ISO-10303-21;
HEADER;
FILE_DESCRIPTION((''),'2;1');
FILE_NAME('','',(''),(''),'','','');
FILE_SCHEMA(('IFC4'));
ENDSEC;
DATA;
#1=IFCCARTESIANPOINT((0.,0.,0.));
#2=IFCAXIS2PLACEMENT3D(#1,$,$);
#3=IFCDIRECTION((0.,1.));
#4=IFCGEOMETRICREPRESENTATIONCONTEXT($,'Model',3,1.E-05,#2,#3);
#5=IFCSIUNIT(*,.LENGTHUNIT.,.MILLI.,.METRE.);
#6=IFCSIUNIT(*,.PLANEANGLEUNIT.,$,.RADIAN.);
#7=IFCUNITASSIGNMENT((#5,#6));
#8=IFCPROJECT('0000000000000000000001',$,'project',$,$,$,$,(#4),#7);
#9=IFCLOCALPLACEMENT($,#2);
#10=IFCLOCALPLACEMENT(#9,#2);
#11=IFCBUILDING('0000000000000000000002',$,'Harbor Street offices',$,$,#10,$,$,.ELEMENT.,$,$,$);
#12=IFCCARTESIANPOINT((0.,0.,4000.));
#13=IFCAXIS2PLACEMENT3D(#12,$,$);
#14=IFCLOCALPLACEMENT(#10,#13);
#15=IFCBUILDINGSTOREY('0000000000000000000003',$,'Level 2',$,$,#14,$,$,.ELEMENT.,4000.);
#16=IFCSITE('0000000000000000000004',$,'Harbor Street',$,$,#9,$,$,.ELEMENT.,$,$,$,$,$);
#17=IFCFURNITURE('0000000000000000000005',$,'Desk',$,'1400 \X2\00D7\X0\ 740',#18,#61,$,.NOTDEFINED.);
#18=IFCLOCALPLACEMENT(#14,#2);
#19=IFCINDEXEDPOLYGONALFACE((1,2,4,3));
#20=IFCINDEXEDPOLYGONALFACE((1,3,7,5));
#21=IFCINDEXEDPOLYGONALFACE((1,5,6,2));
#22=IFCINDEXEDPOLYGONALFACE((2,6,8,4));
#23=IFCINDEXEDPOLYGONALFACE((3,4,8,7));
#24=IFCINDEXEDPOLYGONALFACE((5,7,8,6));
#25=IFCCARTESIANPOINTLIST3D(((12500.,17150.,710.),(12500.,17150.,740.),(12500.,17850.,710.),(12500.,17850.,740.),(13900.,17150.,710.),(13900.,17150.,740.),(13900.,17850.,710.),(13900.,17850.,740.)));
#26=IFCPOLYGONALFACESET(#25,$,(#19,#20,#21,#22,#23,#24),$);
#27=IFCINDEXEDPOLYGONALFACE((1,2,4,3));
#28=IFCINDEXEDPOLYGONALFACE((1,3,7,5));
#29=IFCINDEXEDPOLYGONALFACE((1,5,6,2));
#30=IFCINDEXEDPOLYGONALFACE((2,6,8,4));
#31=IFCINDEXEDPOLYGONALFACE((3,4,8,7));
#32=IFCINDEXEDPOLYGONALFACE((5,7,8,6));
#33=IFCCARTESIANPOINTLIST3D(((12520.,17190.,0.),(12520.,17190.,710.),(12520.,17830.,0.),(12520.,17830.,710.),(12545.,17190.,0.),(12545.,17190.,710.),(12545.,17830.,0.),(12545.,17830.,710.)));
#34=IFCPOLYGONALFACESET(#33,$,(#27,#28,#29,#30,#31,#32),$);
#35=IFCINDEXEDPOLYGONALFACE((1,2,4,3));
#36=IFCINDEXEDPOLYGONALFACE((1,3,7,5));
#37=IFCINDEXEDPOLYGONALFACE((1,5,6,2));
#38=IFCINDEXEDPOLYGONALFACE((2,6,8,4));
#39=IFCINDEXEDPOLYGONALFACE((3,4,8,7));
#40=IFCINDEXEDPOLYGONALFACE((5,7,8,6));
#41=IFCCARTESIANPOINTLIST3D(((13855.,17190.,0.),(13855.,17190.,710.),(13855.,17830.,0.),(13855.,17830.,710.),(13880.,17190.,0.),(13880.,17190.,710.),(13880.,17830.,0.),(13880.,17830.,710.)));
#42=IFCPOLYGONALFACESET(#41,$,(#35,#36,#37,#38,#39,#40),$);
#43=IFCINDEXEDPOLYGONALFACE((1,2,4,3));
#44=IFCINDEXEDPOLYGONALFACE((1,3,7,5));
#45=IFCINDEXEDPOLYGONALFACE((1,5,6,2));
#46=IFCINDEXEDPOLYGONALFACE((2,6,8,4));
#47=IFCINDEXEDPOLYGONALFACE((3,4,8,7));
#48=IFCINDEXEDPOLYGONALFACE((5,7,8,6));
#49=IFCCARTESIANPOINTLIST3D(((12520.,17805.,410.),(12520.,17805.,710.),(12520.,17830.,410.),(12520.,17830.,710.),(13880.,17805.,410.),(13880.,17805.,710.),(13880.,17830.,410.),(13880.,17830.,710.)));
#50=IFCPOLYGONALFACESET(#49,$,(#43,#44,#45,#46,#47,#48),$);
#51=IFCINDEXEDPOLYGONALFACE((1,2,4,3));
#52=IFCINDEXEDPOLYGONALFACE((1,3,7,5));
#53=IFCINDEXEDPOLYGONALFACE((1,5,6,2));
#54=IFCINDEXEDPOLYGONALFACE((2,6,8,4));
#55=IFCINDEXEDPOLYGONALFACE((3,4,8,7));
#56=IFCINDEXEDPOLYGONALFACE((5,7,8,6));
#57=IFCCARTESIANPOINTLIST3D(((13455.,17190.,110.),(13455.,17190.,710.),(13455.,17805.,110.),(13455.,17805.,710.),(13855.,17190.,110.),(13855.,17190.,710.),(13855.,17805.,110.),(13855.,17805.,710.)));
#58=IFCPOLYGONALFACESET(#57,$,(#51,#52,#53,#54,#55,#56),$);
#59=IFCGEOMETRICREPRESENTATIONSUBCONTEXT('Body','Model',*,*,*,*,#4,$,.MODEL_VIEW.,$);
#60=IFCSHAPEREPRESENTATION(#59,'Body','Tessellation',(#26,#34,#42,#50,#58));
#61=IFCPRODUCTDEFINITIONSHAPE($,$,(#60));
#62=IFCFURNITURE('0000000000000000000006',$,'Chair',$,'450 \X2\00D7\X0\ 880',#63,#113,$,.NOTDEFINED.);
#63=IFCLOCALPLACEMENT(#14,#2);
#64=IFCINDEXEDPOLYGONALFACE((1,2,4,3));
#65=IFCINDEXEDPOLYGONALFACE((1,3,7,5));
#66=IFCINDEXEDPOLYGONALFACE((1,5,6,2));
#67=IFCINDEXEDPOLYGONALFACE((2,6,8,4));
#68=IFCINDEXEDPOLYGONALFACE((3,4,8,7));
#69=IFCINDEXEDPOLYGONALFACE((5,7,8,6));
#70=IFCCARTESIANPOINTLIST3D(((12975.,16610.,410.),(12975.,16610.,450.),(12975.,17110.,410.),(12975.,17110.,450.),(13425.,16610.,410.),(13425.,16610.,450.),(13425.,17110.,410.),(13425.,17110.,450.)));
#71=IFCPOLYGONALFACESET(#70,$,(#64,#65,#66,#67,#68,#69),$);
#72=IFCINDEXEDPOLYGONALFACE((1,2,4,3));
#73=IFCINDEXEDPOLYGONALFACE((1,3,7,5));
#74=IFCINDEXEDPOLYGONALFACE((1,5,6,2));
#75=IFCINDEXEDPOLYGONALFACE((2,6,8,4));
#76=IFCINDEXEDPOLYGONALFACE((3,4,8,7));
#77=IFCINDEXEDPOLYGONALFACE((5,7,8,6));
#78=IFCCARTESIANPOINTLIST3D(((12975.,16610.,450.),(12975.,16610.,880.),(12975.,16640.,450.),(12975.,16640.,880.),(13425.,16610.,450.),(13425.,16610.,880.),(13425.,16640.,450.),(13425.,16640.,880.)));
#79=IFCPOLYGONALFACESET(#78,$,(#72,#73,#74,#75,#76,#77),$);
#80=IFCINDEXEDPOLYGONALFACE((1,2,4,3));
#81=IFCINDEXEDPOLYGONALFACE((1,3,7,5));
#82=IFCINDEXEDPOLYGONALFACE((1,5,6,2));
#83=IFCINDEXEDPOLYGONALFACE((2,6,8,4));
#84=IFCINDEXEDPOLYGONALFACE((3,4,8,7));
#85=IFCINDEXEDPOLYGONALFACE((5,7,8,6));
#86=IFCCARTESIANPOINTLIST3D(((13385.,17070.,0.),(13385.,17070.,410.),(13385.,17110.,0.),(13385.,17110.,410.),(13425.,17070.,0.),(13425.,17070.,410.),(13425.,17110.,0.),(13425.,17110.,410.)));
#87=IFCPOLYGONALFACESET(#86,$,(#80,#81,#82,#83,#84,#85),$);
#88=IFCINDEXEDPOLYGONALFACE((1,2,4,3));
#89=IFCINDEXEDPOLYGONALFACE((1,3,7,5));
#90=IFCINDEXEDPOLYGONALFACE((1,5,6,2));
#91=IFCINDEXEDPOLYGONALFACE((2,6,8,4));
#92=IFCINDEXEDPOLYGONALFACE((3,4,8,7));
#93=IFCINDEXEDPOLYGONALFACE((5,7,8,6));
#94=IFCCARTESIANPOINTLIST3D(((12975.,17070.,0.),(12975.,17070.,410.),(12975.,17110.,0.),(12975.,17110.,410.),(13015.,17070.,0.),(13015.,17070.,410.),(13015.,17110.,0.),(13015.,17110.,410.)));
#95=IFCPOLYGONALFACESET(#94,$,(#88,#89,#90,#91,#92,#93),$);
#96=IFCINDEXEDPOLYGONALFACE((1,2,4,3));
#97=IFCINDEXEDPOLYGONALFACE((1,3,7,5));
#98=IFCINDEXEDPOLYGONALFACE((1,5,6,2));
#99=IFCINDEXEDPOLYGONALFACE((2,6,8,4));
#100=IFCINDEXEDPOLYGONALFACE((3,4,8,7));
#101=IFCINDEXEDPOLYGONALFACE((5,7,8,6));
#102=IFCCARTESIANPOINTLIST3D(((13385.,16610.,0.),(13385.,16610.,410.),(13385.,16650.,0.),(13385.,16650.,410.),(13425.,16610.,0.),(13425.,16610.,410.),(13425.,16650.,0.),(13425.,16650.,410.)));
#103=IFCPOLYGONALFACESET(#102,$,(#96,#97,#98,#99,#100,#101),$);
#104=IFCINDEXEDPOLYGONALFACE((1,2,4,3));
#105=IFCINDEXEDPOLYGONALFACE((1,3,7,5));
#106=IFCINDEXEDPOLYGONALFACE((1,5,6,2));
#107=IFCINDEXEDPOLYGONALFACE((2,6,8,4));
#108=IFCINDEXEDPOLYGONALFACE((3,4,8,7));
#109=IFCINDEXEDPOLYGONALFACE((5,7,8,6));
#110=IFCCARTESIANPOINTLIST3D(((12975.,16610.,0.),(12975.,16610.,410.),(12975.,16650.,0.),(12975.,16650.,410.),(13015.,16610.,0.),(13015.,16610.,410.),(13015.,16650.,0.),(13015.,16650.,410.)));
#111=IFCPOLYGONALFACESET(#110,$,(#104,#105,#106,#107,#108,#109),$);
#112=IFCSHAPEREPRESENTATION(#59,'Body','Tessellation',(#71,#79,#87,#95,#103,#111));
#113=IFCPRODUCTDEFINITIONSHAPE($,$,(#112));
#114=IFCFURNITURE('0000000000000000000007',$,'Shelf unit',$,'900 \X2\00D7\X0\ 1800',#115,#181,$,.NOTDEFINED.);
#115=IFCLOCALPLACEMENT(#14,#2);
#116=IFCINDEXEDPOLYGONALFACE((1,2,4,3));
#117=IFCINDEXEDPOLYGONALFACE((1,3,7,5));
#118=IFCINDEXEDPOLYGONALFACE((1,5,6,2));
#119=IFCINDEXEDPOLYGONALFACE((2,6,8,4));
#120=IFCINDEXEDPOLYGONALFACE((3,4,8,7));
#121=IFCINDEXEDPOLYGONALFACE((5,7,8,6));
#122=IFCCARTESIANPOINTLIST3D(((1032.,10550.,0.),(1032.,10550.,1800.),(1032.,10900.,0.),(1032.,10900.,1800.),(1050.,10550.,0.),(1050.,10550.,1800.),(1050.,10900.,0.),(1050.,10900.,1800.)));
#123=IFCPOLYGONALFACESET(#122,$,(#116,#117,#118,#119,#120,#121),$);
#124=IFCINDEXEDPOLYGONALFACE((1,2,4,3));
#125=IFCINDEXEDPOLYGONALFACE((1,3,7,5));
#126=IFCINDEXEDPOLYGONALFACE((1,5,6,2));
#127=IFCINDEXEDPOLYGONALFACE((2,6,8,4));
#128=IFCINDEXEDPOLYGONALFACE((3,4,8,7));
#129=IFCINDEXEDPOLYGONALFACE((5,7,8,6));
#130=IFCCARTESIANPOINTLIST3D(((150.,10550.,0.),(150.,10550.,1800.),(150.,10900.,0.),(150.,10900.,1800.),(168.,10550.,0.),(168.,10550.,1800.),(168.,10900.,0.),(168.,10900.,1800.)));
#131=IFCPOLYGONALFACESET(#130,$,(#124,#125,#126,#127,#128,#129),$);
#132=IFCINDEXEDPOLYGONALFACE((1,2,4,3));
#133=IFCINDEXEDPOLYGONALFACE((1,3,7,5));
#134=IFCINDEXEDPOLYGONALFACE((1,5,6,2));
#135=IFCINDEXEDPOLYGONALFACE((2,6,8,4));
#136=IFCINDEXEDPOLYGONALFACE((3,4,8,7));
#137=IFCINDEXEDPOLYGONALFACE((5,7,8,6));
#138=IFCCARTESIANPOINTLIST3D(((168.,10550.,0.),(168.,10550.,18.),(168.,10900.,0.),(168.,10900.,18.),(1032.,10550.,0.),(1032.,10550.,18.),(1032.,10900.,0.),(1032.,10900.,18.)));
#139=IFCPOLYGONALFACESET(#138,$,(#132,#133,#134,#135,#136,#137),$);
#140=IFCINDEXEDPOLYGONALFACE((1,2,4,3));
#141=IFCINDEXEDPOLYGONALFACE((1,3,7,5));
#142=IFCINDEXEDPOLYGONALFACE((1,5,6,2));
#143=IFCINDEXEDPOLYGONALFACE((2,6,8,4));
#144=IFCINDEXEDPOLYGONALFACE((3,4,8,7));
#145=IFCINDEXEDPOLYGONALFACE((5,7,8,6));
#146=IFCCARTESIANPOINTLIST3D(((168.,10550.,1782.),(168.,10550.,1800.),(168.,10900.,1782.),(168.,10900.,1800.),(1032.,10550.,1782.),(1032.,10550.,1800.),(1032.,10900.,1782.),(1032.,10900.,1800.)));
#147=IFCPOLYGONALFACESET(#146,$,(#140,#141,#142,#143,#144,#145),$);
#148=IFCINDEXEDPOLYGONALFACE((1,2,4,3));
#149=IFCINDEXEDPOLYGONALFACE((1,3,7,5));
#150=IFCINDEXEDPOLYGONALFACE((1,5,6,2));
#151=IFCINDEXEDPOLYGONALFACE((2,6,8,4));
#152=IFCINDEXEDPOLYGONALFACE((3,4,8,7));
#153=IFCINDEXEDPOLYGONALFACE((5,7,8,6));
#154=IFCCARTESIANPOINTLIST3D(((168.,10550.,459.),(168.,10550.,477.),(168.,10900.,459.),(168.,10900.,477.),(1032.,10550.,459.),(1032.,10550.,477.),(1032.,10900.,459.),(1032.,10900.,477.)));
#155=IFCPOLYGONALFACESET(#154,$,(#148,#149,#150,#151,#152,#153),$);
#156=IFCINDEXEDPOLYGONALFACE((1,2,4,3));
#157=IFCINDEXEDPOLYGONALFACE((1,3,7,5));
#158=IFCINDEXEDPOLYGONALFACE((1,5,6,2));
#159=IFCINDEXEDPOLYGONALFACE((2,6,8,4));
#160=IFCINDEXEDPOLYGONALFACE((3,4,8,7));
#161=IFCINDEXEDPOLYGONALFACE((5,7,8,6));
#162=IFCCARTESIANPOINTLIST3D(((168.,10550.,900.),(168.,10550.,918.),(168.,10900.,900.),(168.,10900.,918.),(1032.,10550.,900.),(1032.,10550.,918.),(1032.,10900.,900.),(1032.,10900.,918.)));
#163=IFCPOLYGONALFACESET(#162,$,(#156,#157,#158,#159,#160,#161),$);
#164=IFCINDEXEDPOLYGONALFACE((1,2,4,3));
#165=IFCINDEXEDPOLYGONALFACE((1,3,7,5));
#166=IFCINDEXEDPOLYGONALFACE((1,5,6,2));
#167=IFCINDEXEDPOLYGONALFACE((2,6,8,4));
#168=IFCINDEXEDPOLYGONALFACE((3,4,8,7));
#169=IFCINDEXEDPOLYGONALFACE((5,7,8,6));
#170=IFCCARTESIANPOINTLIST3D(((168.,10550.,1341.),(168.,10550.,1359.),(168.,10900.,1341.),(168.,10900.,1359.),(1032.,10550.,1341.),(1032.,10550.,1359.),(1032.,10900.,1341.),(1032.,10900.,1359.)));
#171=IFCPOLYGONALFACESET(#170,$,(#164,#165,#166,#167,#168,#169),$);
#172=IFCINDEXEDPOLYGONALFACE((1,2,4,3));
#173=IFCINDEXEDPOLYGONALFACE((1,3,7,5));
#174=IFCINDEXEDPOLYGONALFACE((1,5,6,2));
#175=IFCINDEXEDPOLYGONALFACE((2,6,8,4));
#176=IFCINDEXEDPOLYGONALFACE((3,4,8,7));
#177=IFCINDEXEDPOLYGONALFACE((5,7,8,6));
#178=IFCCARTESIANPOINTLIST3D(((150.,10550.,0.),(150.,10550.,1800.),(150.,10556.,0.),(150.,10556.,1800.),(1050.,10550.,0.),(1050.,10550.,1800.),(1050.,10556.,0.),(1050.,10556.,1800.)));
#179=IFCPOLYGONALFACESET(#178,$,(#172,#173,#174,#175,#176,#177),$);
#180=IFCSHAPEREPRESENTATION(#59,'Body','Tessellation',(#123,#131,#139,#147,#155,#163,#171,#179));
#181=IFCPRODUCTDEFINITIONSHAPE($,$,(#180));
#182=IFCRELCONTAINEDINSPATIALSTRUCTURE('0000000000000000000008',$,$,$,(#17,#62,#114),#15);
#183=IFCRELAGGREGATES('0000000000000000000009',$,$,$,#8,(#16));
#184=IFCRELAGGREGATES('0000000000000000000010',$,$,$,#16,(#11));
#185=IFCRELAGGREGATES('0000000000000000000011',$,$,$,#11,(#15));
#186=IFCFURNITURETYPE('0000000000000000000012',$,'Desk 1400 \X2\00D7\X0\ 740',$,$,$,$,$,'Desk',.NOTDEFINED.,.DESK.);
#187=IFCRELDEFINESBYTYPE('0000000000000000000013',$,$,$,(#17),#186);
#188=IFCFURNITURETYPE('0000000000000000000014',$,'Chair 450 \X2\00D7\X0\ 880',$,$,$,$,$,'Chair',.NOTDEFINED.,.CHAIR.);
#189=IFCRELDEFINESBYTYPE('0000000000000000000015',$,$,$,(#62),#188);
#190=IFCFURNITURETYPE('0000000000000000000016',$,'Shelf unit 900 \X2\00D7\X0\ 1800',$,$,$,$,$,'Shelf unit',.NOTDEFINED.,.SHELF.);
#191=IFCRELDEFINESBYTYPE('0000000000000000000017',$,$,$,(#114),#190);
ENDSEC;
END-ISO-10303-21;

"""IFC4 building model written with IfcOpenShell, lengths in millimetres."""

from ifc_helpers import new_model, si_unit, direction, frame, origin, place, context, subcontext, project, spatial, polyline, outline, extrude, source, transform, mapped, type_object, type_shapes, element, save


model = new_model("IFC4")

# Units and contexts
model_context = context("Model", 3, precision=1e-05, world=origin(), true_north=direction((0.0, 1.0)))
body_context = subcontext(model_context, "Body", "Model", "MODEL_VIEW")
ifc_project = project(units=[si_unit("LENGTHUNIT", "METRE", prefix="MILLI"), si_unit("PLANEANGLEUNIT", "RADIAN")], contexts=[model_context])

# Site, building, storey
site_placement = place(None, origin())
site = spatial("IfcSite", under=ifc_project, at=site_placement, Name="Harbor Street", CompositionType="ELEMENT")
building_placement = place(site_placement, origin())
building = spatial("IfcBuilding", under=site, at=building_placement, Name="Harbor Street offices", CompositionType="ELEMENT")
storey_placement = place(building_placement, frame((0.0, 0.0, 4000.0)))
storey = spatial("IfcBuildingStorey", under=building, at=storey_placement, Name="Level 2", CompositionType="ELEMENT", Elevation=4000.0)

# Furniture
furniture_type_1 = type_object("IfcFurnitureType", Name="Desk 1400 × 740", ElementType="Desk", AssemblyPlace="NOTDEFINED", PredefinedType="DESK")
shared_shape_1 = source(origin(), body_context, "Body", "SweptSolid", [
    extrude(outline(polyline([(-700.0, 0.0), (700.0, 0.0), (700.0, 700.0), (-700.0, 700.0), (-700.0, 0.0)])), frame((0.0, 0.0, 710.0)), (0.0, 0.0, 1.0), 30.0),
    extrude(outline(polyline([(-680.0, 40.0), (-655.0, 40.0), (-655.0, 680.0), (-680.0, 680.0), (-680.0, 40.0)])), origin(), (0.0, 0.0, 1.0), 710.0),
    extrude(outline(polyline([(655.0, 40.0), (680.0, 40.0), (680.0, 680.0), (655.0, 680.0), (655.0, 40.0)])), origin(), (0.0, 0.0, 1.0), 710.0),
    extrude(outline(polyline([(-680.0, 655.0), (680.0, 655.0), (680.0, 680.0), (-680.0, 680.0), (-680.0, 655.0)])), frame((0.0, 0.0, 410.0)), (0.0, 0.0, 1.0), 300.0),
    extrude(outline(polyline([(255.0, 40.0), (655.0, 40.0), (655.0, 655.0), (255.0, 655.0), (255.0, 40.0)])), frame((0.0, 0.0, 110.0)), (0.0, 0.0, 1.0), 600.0),
])
type_shapes(furniture_type_1, [shared_shape_1])
furniture_1_placement = place(storey_placement, frame((13200.0, 17150.0, 0.0), z_axis=(0.0, 0.0, 1.0), x_axis=(1.0, 0.0, 0.0)))
element("IfcFurniture", 1, at=furniture_1_placement, inside=storey, type_object=furniture_type_1, Name="Desk", ObjectType="1400 × 740", PredefinedType="NOTDEFINED", context=body_context, shape_type="MappedRepresentation", body=[
    mapped(shared_shape_1, transform((0.0, 0.0, 0.0))),
])
furniture_type_2 = type_object("IfcFurnitureType", Name="Chair 450 × 880", ElementType="Chair", AssemblyPlace="NOTDEFINED", PredefinedType="CHAIR")
shared_shape_2 = source(origin(), body_context, "Body", "SweptSolid", [
    extrude(outline(polyline([(-225.0, 0.0), (225.0, 0.0), (225.0, 500.0), (-225.0, 500.0), (-225.0, 0.0)])), frame((0.0, 0.0, 410.0)), (0.0, 0.0, 1.0), 40.0),
    extrude(outline(polyline([(-225.0, 470.0), (225.0, 470.0), (225.0, 500.0), (-225.0, 500.0), (-225.0, 470.0)])), frame((0.0, 0.0, 450.0)), (0.0, 0.0, 1.0), 430.0),
    extrude(outline(polyline([(-225.0, 0.0), (-185.0, 0.0), (-185.0, 40.0), (-225.0, 40.0), (-225.0, 0.0)])), origin(), (0.0, 0.0, 1.0), 410.0),
    extrude(outline(polyline([(185.0, 0.0), (225.0, 0.0), (225.0, 40.0), (185.0, 40.0), (185.0, 0.0)])), origin(), (0.0, 0.0, 1.0), 410.0),
    extrude(outline(polyline([(-225.0, 460.0), (-185.0, 460.0), (-185.0, 500.0), (-225.0, 500.0), (-225.0, 460.0)])), origin(), (0.0, 0.0, 1.0), 410.0),
    extrude(outline(polyline([(185.0, 460.0), (225.0, 460.0), (225.0, 500.0), (185.0, 500.0), (185.0, 460.0)])), origin(), (0.0, 0.0, 1.0), 410.0),
])
type_shapes(furniture_type_2, [shared_shape_2])
furniture_2_placement = place(storey_placement, frame((13200.0, 17110.0, 0.0), z_axis=(0.0, 0.0, 1.0), x_axis=(-1.0, 0.0, 0.0)))
element("IfcFurniture", 2, at=furniture_2_placement, inside=storey, type_object=furniture_type_2, Name="Chair", ObjectType="450 × 880", PredefinedType="NOTDEFINED", context=body_context, shape_type="MappedRepresentation", body=[
    mapped(shared_shape_2, transform((0.0, 0.0, 0.0))),
])
furniture_type_3 = type_object("IfcFurnitureType", Name="Shelf unit 900 × 1800", ElementType="Shelf unit", AssemblyPlace="NOTDEFINED", PredefinedType="SHELF")
shared_shape_3 = source(origin(), body_context, "Body", "SweptSolid", [
    extrude(outline(polyline([(-450.0, 0.0), (-432.0, 0.0), (-432.0, 350.0), (-450.0, 350.0), (-450.0, 0.0)])), origin(), (0.0, 0.0, 1.0), 1800.0),
    extrude(outline(polyline([(432.0, 0.0), (450.0, 0.0), (450.0, 350.0), (432.0, 350.0), (432.0, 0.0)])), origin(), (0.0, 0.0, 1.0), 1800.0),
    extrude(outline(polyline([(-432.0, 0.0), (432.0, 0.0), (432.0, 350.0), (-432.0, 350.0), (-432.0, 0.0)])), origin(), (0.0, 0.0, 1.0), 18.0),
    extrude(outline(polyline([(-432.0, 0.0), (432.0, 0.0), (432.0, 350.0), (-432.0, 350.0), (-432.0, 0.0)])), frame((0.0, 0.0, 1782.0)), (0.0, 0.0, 1.0), 18.0),
    extrude(outline(polyline([(-432.0, 0.0), (432.0, 0.0), (432.0, 350.0), (-432.0, 350.0), (-432.0, 0.0)])), frame((0.0, 0.0, 459.0)), (0.0, 0.0, 1.0), 18.0),
    extrude(outline(polyline([(-432.0, 0.0), (432.0, 0.0), (432.0, 350.0), (-432.0, 350.0), (-432.0, 0.0)])), frame((0.0, 0.0, 900.0)), (0.0, 0.0, 1.0), 18.0),
    extrude(outline(polyline([(-432.0, 0.0), (432.0, 0.0), (432.0, 350.0), (-432.0, 350.0), (-432.0, 0.0)])), frame((0.0, 0.0, 1341.0)), (0.0, 0.0, 1.0), 18.0),
    extrude(outline(polyline([(-450.0, 344.0), (450.0, 344.0), (450.0, 350.0), (-450.0, 350.0), (-450.0, 344.0)])), origin(), (0.0, 0.0, 1.0), 1800.0),
])
type_shapes(furniture_type_3, [shared_shape_3])
for number, where, z_axis, x_axis, name in (
    (3, (600.0, 10900.0, 0.0), (0.0, 0.0, 1.0), (-1.0, 0.0, 0.0), "Shelf unit"),
):
    element("IfcFurniture", number, at=place(storey_placement, frame(where, z_axis=z_axis, x_axis=x_axis)), inside=storey, type_object=furniture_type_3, Name=name, ObjectType="900 × 1800", PredefinedType="NOTDEFINED", context=body_context, shape_type="MappedRepresentation", body=[
        mapped(shared_shape_3, transform((0.0, 0.0, 0.0))),
    ])

save(model, "model.ifc")
